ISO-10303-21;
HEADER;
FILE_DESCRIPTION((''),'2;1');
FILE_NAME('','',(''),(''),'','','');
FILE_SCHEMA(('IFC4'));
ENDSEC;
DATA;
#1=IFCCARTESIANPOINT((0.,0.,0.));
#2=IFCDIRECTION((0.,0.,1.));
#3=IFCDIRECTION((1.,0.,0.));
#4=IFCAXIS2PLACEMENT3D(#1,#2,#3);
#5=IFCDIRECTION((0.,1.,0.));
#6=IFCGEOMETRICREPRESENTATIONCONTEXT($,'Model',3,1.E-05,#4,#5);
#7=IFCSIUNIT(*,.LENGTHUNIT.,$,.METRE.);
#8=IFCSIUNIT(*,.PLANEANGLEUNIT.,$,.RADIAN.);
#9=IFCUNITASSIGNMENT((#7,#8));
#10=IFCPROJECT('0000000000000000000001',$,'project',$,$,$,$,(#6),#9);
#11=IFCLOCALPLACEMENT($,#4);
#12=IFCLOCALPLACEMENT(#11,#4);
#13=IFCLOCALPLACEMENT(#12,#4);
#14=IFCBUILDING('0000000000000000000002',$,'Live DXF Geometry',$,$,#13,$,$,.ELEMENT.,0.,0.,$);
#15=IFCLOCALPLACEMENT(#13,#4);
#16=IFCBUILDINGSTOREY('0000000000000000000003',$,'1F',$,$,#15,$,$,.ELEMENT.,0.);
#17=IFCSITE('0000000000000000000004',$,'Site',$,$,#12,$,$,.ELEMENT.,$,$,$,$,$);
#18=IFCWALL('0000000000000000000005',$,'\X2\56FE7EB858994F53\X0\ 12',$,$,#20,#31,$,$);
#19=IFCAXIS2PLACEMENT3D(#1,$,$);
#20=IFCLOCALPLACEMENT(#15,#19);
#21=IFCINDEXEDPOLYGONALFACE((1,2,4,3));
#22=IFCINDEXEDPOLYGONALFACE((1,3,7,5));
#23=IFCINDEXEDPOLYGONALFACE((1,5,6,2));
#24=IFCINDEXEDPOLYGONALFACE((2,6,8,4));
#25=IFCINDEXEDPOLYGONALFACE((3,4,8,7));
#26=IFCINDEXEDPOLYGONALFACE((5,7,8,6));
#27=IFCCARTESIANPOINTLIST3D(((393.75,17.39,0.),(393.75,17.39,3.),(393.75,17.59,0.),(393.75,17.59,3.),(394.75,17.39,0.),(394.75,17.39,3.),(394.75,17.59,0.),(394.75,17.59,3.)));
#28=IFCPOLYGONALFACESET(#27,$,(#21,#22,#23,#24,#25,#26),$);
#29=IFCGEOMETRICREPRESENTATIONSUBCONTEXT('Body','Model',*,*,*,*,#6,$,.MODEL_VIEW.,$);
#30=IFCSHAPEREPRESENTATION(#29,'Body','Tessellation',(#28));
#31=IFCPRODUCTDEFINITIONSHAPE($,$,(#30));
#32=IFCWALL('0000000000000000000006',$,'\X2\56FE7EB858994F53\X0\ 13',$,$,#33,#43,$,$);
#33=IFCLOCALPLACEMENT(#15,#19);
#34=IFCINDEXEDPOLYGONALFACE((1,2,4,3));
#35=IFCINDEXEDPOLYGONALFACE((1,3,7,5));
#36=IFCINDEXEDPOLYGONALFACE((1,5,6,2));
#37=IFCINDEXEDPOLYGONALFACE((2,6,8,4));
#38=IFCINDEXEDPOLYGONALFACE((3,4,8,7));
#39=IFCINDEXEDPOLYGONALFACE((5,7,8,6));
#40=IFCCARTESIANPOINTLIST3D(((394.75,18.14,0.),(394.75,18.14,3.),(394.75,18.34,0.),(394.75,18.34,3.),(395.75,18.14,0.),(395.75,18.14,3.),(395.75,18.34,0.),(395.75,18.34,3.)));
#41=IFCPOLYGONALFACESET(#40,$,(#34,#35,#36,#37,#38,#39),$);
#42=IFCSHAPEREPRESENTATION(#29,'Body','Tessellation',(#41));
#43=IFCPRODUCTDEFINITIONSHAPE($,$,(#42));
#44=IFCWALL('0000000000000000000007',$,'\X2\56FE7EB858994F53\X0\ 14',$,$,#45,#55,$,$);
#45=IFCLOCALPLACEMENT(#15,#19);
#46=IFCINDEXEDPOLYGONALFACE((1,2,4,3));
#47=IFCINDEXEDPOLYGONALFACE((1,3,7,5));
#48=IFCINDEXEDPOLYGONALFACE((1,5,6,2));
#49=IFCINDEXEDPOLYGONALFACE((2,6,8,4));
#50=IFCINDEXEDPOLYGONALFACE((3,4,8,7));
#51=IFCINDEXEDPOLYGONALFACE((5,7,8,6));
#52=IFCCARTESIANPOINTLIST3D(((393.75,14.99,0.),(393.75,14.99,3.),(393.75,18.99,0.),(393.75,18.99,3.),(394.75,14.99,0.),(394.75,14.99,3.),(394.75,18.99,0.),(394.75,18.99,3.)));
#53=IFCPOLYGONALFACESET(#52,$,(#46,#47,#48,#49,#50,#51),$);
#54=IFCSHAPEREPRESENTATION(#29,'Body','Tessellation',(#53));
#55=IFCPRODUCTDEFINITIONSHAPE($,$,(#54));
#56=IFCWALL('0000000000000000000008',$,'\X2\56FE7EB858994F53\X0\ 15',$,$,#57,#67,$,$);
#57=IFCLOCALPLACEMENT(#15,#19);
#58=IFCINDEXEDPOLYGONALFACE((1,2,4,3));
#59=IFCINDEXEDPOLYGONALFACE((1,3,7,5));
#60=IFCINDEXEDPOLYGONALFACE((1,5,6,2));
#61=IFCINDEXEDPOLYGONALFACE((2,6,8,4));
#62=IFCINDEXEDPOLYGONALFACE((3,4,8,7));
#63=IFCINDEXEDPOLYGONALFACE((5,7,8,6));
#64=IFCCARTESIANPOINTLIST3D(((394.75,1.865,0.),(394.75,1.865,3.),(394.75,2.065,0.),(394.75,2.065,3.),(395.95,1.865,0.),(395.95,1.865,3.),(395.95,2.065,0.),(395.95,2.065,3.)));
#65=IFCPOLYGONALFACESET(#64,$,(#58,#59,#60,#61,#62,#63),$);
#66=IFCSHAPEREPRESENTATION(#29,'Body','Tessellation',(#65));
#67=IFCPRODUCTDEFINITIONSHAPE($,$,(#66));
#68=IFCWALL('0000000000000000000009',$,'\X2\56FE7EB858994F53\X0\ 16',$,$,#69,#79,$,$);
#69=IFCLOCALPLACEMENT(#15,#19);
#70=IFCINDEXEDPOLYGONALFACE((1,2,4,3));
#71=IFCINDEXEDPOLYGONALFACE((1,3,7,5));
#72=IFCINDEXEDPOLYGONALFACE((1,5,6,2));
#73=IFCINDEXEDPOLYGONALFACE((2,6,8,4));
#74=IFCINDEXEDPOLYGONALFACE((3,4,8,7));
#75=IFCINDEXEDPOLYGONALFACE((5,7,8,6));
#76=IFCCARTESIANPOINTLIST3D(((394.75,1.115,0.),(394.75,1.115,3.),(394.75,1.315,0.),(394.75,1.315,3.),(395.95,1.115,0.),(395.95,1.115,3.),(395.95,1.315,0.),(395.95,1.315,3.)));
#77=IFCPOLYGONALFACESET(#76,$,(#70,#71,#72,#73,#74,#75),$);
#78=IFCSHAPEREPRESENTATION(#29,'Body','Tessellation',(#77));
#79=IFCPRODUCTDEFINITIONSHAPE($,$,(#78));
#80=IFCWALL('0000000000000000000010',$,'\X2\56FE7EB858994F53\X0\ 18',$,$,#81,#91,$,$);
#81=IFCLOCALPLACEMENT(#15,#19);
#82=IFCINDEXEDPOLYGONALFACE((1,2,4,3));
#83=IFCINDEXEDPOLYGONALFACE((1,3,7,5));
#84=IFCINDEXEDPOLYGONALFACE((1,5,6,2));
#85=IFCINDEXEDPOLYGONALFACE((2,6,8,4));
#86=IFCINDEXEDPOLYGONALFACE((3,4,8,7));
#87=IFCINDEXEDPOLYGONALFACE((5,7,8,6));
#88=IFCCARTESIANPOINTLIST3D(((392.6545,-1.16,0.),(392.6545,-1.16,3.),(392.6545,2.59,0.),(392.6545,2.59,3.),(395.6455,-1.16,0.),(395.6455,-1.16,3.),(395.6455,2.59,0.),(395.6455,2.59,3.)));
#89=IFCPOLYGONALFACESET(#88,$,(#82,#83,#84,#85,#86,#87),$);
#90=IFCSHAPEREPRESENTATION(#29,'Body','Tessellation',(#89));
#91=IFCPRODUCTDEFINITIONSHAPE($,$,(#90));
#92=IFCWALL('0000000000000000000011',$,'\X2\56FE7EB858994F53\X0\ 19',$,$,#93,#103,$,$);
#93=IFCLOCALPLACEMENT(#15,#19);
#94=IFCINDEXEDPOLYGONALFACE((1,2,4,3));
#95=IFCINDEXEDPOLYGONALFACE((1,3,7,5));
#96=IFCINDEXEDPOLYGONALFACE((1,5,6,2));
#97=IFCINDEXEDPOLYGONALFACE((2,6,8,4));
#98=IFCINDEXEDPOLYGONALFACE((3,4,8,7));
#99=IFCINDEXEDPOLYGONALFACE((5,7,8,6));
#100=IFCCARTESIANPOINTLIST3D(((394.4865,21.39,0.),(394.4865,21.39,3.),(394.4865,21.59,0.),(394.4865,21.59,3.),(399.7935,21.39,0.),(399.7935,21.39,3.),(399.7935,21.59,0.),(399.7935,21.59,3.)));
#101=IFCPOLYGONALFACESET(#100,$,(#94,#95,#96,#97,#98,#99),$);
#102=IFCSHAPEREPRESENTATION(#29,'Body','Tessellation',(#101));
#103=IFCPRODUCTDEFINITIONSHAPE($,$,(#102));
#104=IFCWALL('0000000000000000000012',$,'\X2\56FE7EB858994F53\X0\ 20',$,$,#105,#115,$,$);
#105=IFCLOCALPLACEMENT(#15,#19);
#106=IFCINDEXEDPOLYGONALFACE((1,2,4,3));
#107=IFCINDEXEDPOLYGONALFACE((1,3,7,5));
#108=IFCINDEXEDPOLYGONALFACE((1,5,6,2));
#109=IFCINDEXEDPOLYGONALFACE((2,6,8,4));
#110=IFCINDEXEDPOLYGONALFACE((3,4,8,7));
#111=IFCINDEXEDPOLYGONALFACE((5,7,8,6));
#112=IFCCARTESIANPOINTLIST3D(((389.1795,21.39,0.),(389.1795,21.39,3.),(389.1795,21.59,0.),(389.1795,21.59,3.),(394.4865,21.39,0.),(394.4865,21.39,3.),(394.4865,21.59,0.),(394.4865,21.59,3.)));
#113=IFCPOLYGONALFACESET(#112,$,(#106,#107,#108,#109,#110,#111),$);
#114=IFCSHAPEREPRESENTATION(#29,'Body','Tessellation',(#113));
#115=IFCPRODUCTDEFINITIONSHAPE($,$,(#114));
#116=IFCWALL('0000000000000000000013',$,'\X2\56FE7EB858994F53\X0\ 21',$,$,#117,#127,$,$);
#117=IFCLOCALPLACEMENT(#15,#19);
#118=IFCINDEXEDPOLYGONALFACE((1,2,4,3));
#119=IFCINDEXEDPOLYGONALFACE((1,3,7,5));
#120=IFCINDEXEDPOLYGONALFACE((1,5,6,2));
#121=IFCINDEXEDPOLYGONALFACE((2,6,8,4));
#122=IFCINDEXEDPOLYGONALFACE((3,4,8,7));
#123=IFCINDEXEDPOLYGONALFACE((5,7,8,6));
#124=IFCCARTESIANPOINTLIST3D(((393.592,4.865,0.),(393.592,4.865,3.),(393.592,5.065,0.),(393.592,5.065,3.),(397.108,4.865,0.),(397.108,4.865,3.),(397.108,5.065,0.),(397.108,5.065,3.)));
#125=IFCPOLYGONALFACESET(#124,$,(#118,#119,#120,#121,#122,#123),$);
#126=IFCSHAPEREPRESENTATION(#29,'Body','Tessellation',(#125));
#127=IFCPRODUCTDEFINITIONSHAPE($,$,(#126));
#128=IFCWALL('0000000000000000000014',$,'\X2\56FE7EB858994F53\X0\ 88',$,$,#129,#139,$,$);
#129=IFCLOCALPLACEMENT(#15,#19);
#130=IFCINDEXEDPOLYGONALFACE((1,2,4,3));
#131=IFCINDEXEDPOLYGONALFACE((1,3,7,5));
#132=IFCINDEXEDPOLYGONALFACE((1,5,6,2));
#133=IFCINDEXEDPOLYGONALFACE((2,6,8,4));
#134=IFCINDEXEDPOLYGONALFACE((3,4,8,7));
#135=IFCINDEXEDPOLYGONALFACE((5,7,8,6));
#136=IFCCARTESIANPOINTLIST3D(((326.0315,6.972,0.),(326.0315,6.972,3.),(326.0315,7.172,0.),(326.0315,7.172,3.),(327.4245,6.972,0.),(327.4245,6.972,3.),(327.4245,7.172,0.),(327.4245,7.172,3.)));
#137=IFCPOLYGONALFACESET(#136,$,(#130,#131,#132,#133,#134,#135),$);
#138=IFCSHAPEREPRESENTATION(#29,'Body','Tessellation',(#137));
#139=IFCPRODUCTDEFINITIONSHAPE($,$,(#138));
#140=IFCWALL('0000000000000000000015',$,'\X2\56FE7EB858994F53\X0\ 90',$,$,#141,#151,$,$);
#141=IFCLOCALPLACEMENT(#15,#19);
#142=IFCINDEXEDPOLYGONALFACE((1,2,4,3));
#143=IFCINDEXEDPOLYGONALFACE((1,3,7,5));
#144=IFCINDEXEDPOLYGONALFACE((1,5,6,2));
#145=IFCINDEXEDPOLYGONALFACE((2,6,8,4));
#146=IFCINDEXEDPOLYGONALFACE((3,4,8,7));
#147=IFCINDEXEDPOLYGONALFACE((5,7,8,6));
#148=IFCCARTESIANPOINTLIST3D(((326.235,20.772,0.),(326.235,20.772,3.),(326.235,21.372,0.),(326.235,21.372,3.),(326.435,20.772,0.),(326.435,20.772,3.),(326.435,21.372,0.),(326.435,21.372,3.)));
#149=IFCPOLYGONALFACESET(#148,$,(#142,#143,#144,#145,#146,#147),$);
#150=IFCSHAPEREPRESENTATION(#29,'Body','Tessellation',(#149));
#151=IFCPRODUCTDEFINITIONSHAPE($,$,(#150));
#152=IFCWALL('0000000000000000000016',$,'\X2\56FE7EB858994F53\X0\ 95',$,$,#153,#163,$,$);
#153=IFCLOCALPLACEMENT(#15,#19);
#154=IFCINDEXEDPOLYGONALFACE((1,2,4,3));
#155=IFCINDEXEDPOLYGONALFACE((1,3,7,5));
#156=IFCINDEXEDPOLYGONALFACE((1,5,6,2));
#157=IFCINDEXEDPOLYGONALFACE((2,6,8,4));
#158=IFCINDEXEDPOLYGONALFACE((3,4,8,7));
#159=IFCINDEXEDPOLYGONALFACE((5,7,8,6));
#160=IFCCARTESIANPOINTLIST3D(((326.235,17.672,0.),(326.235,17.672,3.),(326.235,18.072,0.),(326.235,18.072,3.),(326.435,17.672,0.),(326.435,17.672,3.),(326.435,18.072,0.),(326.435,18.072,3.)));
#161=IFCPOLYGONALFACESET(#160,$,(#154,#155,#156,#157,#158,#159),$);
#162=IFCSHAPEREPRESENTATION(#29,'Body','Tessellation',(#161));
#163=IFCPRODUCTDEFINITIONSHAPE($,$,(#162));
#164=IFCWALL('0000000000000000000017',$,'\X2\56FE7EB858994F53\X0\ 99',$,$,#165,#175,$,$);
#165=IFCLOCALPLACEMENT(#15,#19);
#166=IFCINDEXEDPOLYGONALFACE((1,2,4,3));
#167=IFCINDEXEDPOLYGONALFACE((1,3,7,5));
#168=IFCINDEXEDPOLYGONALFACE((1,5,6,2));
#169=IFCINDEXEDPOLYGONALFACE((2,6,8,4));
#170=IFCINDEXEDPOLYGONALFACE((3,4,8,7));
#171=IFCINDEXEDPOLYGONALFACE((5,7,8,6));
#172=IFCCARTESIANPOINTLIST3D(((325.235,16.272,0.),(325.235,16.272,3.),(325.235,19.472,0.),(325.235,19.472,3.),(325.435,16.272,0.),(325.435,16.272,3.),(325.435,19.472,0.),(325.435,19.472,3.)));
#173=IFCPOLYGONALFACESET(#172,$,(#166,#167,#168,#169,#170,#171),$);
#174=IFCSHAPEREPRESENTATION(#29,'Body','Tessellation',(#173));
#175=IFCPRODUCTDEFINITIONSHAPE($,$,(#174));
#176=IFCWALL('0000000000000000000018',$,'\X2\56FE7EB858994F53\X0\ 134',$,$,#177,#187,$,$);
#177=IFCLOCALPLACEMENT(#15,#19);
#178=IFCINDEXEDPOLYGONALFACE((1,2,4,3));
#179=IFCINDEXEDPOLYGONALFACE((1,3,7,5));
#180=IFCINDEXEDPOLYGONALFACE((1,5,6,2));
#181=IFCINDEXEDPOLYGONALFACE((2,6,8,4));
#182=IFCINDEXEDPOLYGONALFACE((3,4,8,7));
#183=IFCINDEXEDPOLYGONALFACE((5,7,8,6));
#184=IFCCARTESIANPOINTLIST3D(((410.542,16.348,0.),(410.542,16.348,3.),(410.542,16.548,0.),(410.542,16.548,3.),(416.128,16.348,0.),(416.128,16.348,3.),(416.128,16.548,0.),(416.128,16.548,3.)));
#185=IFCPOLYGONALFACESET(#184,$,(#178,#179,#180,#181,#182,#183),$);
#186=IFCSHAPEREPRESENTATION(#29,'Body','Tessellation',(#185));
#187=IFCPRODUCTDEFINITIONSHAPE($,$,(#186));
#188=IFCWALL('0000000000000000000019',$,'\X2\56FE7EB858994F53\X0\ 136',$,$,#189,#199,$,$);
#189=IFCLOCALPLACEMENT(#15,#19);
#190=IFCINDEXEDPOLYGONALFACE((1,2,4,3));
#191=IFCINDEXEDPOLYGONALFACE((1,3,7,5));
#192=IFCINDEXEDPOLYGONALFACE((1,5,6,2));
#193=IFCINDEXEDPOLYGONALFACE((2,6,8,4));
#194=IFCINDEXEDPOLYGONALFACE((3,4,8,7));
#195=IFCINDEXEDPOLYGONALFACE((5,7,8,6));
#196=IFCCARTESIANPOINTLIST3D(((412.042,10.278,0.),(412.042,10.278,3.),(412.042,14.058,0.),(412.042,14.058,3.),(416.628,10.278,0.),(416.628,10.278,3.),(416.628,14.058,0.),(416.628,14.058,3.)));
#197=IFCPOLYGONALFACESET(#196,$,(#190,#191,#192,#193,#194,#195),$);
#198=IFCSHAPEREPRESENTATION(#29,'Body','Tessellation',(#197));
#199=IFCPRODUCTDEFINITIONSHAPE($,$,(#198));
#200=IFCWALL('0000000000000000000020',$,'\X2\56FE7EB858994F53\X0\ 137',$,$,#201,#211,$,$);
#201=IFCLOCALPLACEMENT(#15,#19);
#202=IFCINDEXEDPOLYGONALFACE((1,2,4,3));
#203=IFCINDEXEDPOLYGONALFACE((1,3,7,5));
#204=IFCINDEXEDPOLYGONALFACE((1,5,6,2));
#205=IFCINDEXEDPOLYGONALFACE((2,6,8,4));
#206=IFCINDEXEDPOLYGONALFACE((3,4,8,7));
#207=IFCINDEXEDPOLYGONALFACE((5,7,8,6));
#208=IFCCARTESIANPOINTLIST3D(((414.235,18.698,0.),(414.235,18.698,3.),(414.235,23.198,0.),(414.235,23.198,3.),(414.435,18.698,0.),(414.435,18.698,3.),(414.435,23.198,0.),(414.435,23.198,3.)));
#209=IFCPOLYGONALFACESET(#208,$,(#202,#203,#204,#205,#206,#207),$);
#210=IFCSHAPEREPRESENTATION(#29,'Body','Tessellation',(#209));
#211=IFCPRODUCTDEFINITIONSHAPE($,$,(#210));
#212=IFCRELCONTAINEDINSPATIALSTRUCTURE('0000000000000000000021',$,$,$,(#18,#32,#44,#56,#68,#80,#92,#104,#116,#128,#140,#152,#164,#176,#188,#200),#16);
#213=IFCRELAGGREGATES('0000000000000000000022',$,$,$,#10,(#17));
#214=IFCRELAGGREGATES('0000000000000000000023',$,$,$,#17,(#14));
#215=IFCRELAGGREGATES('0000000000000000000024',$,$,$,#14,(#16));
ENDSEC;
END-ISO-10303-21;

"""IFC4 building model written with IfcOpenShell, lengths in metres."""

from ifc_helpers import new_model, si_unit, direction, frame, frame_2d, origin_with_axes, place, context, subcontext, project, spatial, rectangle, extrude, element, save


model = new_model("IFC4")

# Units and contexts
model_context = context("Model", 3, precision=1e-05, world=origin_with_axes(), true_north=direction((0.0, 1.0, 0.0)))
body_context = subcontext(model_context, "Body", "Model", "MODEL_VIEW")
ifc_project = project(units=[si_unit("LENGTHUNIT", "METRE"), si_unit("PLANEANGLEUNIT", "RADIAN")], contexts=[model_context])

# Site, building, storey
placement = place(None, origin_with_axes())
site_placement = place(placement, origin_with_axes())
site = spatial("IfcSite", under=ifc_project, at=site_placement, Name="Site", CompositionType="ELEMENT")
building_placement = place(site_placement, origin_with_axes())
building = spatial("IfcBuilding", under=site, at=building_placement, Name="Live DXF Geometry", CompositionType="ELEMENT", ElevationOfRefHeight=0.0, ElevationOfTerrain=0.0)
storey_placement = place(building_placement, origin_with_axes())
storey = spatial("IfcBuildingStorey", under=building, at=storey_placement, Name="1F", CompositionType="ELEMENT", Elevation=0.0)

# Walls
for number, where, z_axis, x_axis, name in (
    (1, (394.25, 17.49, 0.0), (0.0, 0.0, 1.0), (1.0, 0.0, 0.0), "图纸墙体 12"),
    (2, (395.25, 18.24, 0.0), (0.0, 0.0, 1.0), (-1.0, 0.0, 0.0), "图纸墙体 13"),
):
    element("IfcWall", number, at=place(storey_placement, frame(where, z_axis=z_axis, x_axis=x_axis)), inside=storey, Name=name, context=body_context, shape_type="SweptSolid", body=[
        extrude(rectangle(XDim=1.0, YDim=0.2, at=frame_2d((0.0, 0.0), x_axis=(1.0, 0.0, 0.0))), frame((0.0, 0.0, 0.0), z_axis=(0.0, 0.0, 1.0)), (0.0, 0.0, 1.0), 3.0),
    ])
wall_1_placement = place(storey_placement, frame((394.25, 16.99, 0.0), z_axis=(0.0, 0.0, 1.0), x_axis=(1.0, 0.0, 0.0)))
element("IfcWall", 3, at=wall_1_placement, inside=storey, Name="图纸墙体 14", context=body_context, shape_type="SweptSolid", body=[
    extrude(rectangle(XDim=1.0, YDim=4.0, at=frame_2d((0.0, 0.0), x_axis=(1.0, 0.0, 0.0))), frame((0.0, 0.0, 0.0), z_axis=(0.0, 0.0, 1.0)), (0.0, 0.0, 1.0), 3.0),
])
for number, where, z_axis, x_axis, name in (
    (4, (395.35, 1.965, 0.0), (0.0, 0.0, 1.0), (-1.0, 0.0, 0.0), "图纸墙体 15"),
    (5, (395.35, 1.215, 0.0), (0.0, 0.0, 1.0), (-1.0, 0.0, 0.0), "图纸墙体 16"),
):
    element("IfcWall", number, at=place(storey_placement, frame(where, z_axis=z_axis, x_axis=x_axis)), inside=storey, Name=name, context=body_context, shape_type="SweptSolid", body=[
        extrude(rectangle(XDim=1.2, YDim=0.2, at=frame_2d((0.0, 0.0), x_axis=(1.0, 0.0, 0.0))), frame((0.0, 0.0, 0.0), z_axis=(0.0, 0.0, 1.0)), (0.0, 0.0, 1.0), 3.0),
    ])
wall_2_placement = place(storey_placement, frame((394.15, 0.715, 0.0), z_axis=(0.0, 0.0, 1.0), x_axis=(1.0, 0.0, 0.0)))
element("IfcWall", 6, at=wall_2_placement, inside=storey, Name="图纸墙体 18", context=body_context, shape_type="SweptSolid", body=[
    extrude(rectangle(XDim=2.991, YDim=3.75, at=frame_2d((0.0, 0.0), x_axis=(1.0, 0.0, 0.0))), frame((0.0, 0.0, 0.0), z_axis=(0.0, 0.0, 1.0)), (0.0, 0.0, 1.0), 3.0),
])
for number, where, z_axis, x_axis, name in (
    (7, (397.14, 21.49, 0.0), (0.0, 0.0, 1.0), (-1.0, 0.0, 0.0), "图纸墙体 19"),
    (8, (391.833, 21.49, 0.0), (0.0, 0.0, 1.0), (1.0, 0.0, 0.0), "图纸墙体 20"),
):
    element("IfcWall", number, at=place(storey_placement, frame(where, z_axis=z_axis, x_axis=x_axis)), inside=storey, Name=name, context=body_context, shape_type="SweptSolid", body=[
        extrude(rectangle(XDim=5.307, YDim=0.2, at=frame_2d((0.0, 0.0), x_axis=(1.0, 0.0, 0.0))), frame((0.0, 0.0, 0.0), z_axis=(0.0, 0.0, 1.0)), (0.0, 0.0, 1.0), 3.0),
    ])
wall_3_placement = place(storey_placement, frame((395.35, 4.965, 0.0), z_axis=(0.0, 0.0, 1.0), x_axis=(-1.0, 0.0, 0.0)))
element("IfcWall", 9, at=wall_3_placement, inside=storey, Name="图纸墙体 21", context=body_context, shape_type="SweptSolid", body=[
    extrude(rectangle(XDim=3.516, YDim=0.2, at=frame_2d((0.0, 0.0), x_axis=(1.0, 0.0, 0.0))), frame((0.0, 0.0, 0.0), z_axis=(0.0, 0.0, 1.0)), (0.0, 0.0, 1.0), 3.0),
])
wall_4_placement = place(storey_placement, frame((326.728, 7.072, 0.0), z_axis=(0.0, 0.0, 1.0), x_axis=(-1.0, 0.0, 0.0)))
element("IfcWall", 10, at=wall_4_placement, inside=storey, Name="图纸墙体 88", context=body_context, shape_type="SweptSolid", body=[
    extrude(rectangle(XDim=1.393, YDim=0.2, at=frame_2d((0.0, 0.0), x_axis=(1.0, 0.0, 0.0))), frame((0.0, 0.0, 0.0), z_axis=(0.0, 0.0, 1.0)), (0.0, 0.0, 1.0), 3.0),
])
wall_5_placement = place(storey_placement, frame((326.335, 21.072, 0.0), z_axis=(0.0, 0.0, 1.0), x_axis=(0.0, 1.0, 0.0)))
element("IfcWall", 11, at=wall_5_placement, inside=storey, Name="图纸墙体 90", context=body_context, shape_type="SweptSolid", body=[
    extrude(rectangle(XDim=0.6, YDim=0.2, at=frame_2d((0.0, 0.0), x_axis=(1.0, 0.0, 0.0))), frame((0.0, 0.0, 0.0), z_axis=(0.0, 0.0, 1.0)), (0.0, 0.0, 1.0), 3.0),
])
wall_6_placement = place(storey_placement, frame((326.335, 17.872, 0.0), z_axis=(0.0, 0.0, 1.0), x_axis=(0.0, -1.0, 0.0)))
element("IfcWall", 12, at=wall_6_placement, inside=storey, Name="图纸墙体 95", context=body_context, shape_type="SweptSolid", body=[
    extrude(rectangle(XDim=0.4, YDim=0.2, at=frame_2d((0.0, 0.0), x_axis=(1.0, 0.0, 0.0))), frame((0.0, 0.0, 0.0), z_axis=(0.0, 0.0, 1.0)), (0.0, 0.0, 1.0), 3.0),
])
wall_7_placement = place(storey_placement, frame((325.335, 17.872, 0.0), z_axis=(0.0, 0.0, 1.0), x_axis=(0.0, 1.0, 0.0)))
element("IfcWall", 13, at=wall_7_placement, inside=storey, Name="图纸墙体 99", context=body_context, shape_type="SweptSolid", body=[
    extrude(rectangle(XDim=3.2, YDim=0.2, at=frame_2d((0.0, 0.0), x_axis=(1.0, 0.0, 0.0))), frame((0.0, 0.0, 0.0), z_axis=(0.0, 0.0, 1.0)), (0.0, 0.0, 1.0), 3.0),
])
wall_8_placement = place(storey_placement, frame((413.335, 16.448, 0.0), z_axis=(0.0, 0.0, 1.0), x_axis=(1.0, 0.0, 0.0)))
element("IfcWall", 14, at=wall_8_placement, inside=storey, Name="图纸墙体 134", context=body_context, shape_type="SweptSolid", body=[
    extrude(rectangle(XDim=5.586, YDim=0.2, at=frame_2d((0.0, 0.0), x_axis=(1.0, 0.0, 0.0))), frame((0.0, 0.0, 0.0), z_axis=(0.0, 0.0, 1.0)), (0.0, 0.0, 1.0), 3.0),
])
wall_9_placement = place(storey_placement, frame((414.335, 12.168, 0.0), z_axis=(0.0, 0.0, 1.0), x_axis=(1.0, 0.0, 0.0)))
element("IfcWall", 15, at=wall_9_placement, inside=storey, Name="图纸墙体 136", context=body_context, shape_type="SweptSolid", body=[
    extrude(rectangle(XDim=4.586, YDim=3.78, at=frame_2d((0.0, 0.0), x_axis=(1.0, 0.0, 0.0))), frame((0.0, 0.0, 0.0), z_axis=(0.0, 0.0, 1.0)), (0.0, 0.0, 1.0), 3.0),
])
wall_10_placement = place(storey_placement, frame((414.335, 20.948, 0.0), z_axis=(0.0, 0.0, 1.0), x_axis=(0.0, -1.0, 0.0)))
element("IfcWall", 16, at=wall_10_placement, inside=storey, Name="图纸墙体 137", context=body_context, shape_type="SweptSolid", body=[
    extrude(rectangle(XDim=4.5, YDim=0.2, at=frame_2d((0.0, 0.0), x_axis=(1.0, 0.0, 0.0))), frame((0.0, 0.0, 0.0), z_axis=(0.0, 0.0, 1.0)), (0.0, 0.0, 1.0), 3.0),
])

save(model, "model.ifc")
